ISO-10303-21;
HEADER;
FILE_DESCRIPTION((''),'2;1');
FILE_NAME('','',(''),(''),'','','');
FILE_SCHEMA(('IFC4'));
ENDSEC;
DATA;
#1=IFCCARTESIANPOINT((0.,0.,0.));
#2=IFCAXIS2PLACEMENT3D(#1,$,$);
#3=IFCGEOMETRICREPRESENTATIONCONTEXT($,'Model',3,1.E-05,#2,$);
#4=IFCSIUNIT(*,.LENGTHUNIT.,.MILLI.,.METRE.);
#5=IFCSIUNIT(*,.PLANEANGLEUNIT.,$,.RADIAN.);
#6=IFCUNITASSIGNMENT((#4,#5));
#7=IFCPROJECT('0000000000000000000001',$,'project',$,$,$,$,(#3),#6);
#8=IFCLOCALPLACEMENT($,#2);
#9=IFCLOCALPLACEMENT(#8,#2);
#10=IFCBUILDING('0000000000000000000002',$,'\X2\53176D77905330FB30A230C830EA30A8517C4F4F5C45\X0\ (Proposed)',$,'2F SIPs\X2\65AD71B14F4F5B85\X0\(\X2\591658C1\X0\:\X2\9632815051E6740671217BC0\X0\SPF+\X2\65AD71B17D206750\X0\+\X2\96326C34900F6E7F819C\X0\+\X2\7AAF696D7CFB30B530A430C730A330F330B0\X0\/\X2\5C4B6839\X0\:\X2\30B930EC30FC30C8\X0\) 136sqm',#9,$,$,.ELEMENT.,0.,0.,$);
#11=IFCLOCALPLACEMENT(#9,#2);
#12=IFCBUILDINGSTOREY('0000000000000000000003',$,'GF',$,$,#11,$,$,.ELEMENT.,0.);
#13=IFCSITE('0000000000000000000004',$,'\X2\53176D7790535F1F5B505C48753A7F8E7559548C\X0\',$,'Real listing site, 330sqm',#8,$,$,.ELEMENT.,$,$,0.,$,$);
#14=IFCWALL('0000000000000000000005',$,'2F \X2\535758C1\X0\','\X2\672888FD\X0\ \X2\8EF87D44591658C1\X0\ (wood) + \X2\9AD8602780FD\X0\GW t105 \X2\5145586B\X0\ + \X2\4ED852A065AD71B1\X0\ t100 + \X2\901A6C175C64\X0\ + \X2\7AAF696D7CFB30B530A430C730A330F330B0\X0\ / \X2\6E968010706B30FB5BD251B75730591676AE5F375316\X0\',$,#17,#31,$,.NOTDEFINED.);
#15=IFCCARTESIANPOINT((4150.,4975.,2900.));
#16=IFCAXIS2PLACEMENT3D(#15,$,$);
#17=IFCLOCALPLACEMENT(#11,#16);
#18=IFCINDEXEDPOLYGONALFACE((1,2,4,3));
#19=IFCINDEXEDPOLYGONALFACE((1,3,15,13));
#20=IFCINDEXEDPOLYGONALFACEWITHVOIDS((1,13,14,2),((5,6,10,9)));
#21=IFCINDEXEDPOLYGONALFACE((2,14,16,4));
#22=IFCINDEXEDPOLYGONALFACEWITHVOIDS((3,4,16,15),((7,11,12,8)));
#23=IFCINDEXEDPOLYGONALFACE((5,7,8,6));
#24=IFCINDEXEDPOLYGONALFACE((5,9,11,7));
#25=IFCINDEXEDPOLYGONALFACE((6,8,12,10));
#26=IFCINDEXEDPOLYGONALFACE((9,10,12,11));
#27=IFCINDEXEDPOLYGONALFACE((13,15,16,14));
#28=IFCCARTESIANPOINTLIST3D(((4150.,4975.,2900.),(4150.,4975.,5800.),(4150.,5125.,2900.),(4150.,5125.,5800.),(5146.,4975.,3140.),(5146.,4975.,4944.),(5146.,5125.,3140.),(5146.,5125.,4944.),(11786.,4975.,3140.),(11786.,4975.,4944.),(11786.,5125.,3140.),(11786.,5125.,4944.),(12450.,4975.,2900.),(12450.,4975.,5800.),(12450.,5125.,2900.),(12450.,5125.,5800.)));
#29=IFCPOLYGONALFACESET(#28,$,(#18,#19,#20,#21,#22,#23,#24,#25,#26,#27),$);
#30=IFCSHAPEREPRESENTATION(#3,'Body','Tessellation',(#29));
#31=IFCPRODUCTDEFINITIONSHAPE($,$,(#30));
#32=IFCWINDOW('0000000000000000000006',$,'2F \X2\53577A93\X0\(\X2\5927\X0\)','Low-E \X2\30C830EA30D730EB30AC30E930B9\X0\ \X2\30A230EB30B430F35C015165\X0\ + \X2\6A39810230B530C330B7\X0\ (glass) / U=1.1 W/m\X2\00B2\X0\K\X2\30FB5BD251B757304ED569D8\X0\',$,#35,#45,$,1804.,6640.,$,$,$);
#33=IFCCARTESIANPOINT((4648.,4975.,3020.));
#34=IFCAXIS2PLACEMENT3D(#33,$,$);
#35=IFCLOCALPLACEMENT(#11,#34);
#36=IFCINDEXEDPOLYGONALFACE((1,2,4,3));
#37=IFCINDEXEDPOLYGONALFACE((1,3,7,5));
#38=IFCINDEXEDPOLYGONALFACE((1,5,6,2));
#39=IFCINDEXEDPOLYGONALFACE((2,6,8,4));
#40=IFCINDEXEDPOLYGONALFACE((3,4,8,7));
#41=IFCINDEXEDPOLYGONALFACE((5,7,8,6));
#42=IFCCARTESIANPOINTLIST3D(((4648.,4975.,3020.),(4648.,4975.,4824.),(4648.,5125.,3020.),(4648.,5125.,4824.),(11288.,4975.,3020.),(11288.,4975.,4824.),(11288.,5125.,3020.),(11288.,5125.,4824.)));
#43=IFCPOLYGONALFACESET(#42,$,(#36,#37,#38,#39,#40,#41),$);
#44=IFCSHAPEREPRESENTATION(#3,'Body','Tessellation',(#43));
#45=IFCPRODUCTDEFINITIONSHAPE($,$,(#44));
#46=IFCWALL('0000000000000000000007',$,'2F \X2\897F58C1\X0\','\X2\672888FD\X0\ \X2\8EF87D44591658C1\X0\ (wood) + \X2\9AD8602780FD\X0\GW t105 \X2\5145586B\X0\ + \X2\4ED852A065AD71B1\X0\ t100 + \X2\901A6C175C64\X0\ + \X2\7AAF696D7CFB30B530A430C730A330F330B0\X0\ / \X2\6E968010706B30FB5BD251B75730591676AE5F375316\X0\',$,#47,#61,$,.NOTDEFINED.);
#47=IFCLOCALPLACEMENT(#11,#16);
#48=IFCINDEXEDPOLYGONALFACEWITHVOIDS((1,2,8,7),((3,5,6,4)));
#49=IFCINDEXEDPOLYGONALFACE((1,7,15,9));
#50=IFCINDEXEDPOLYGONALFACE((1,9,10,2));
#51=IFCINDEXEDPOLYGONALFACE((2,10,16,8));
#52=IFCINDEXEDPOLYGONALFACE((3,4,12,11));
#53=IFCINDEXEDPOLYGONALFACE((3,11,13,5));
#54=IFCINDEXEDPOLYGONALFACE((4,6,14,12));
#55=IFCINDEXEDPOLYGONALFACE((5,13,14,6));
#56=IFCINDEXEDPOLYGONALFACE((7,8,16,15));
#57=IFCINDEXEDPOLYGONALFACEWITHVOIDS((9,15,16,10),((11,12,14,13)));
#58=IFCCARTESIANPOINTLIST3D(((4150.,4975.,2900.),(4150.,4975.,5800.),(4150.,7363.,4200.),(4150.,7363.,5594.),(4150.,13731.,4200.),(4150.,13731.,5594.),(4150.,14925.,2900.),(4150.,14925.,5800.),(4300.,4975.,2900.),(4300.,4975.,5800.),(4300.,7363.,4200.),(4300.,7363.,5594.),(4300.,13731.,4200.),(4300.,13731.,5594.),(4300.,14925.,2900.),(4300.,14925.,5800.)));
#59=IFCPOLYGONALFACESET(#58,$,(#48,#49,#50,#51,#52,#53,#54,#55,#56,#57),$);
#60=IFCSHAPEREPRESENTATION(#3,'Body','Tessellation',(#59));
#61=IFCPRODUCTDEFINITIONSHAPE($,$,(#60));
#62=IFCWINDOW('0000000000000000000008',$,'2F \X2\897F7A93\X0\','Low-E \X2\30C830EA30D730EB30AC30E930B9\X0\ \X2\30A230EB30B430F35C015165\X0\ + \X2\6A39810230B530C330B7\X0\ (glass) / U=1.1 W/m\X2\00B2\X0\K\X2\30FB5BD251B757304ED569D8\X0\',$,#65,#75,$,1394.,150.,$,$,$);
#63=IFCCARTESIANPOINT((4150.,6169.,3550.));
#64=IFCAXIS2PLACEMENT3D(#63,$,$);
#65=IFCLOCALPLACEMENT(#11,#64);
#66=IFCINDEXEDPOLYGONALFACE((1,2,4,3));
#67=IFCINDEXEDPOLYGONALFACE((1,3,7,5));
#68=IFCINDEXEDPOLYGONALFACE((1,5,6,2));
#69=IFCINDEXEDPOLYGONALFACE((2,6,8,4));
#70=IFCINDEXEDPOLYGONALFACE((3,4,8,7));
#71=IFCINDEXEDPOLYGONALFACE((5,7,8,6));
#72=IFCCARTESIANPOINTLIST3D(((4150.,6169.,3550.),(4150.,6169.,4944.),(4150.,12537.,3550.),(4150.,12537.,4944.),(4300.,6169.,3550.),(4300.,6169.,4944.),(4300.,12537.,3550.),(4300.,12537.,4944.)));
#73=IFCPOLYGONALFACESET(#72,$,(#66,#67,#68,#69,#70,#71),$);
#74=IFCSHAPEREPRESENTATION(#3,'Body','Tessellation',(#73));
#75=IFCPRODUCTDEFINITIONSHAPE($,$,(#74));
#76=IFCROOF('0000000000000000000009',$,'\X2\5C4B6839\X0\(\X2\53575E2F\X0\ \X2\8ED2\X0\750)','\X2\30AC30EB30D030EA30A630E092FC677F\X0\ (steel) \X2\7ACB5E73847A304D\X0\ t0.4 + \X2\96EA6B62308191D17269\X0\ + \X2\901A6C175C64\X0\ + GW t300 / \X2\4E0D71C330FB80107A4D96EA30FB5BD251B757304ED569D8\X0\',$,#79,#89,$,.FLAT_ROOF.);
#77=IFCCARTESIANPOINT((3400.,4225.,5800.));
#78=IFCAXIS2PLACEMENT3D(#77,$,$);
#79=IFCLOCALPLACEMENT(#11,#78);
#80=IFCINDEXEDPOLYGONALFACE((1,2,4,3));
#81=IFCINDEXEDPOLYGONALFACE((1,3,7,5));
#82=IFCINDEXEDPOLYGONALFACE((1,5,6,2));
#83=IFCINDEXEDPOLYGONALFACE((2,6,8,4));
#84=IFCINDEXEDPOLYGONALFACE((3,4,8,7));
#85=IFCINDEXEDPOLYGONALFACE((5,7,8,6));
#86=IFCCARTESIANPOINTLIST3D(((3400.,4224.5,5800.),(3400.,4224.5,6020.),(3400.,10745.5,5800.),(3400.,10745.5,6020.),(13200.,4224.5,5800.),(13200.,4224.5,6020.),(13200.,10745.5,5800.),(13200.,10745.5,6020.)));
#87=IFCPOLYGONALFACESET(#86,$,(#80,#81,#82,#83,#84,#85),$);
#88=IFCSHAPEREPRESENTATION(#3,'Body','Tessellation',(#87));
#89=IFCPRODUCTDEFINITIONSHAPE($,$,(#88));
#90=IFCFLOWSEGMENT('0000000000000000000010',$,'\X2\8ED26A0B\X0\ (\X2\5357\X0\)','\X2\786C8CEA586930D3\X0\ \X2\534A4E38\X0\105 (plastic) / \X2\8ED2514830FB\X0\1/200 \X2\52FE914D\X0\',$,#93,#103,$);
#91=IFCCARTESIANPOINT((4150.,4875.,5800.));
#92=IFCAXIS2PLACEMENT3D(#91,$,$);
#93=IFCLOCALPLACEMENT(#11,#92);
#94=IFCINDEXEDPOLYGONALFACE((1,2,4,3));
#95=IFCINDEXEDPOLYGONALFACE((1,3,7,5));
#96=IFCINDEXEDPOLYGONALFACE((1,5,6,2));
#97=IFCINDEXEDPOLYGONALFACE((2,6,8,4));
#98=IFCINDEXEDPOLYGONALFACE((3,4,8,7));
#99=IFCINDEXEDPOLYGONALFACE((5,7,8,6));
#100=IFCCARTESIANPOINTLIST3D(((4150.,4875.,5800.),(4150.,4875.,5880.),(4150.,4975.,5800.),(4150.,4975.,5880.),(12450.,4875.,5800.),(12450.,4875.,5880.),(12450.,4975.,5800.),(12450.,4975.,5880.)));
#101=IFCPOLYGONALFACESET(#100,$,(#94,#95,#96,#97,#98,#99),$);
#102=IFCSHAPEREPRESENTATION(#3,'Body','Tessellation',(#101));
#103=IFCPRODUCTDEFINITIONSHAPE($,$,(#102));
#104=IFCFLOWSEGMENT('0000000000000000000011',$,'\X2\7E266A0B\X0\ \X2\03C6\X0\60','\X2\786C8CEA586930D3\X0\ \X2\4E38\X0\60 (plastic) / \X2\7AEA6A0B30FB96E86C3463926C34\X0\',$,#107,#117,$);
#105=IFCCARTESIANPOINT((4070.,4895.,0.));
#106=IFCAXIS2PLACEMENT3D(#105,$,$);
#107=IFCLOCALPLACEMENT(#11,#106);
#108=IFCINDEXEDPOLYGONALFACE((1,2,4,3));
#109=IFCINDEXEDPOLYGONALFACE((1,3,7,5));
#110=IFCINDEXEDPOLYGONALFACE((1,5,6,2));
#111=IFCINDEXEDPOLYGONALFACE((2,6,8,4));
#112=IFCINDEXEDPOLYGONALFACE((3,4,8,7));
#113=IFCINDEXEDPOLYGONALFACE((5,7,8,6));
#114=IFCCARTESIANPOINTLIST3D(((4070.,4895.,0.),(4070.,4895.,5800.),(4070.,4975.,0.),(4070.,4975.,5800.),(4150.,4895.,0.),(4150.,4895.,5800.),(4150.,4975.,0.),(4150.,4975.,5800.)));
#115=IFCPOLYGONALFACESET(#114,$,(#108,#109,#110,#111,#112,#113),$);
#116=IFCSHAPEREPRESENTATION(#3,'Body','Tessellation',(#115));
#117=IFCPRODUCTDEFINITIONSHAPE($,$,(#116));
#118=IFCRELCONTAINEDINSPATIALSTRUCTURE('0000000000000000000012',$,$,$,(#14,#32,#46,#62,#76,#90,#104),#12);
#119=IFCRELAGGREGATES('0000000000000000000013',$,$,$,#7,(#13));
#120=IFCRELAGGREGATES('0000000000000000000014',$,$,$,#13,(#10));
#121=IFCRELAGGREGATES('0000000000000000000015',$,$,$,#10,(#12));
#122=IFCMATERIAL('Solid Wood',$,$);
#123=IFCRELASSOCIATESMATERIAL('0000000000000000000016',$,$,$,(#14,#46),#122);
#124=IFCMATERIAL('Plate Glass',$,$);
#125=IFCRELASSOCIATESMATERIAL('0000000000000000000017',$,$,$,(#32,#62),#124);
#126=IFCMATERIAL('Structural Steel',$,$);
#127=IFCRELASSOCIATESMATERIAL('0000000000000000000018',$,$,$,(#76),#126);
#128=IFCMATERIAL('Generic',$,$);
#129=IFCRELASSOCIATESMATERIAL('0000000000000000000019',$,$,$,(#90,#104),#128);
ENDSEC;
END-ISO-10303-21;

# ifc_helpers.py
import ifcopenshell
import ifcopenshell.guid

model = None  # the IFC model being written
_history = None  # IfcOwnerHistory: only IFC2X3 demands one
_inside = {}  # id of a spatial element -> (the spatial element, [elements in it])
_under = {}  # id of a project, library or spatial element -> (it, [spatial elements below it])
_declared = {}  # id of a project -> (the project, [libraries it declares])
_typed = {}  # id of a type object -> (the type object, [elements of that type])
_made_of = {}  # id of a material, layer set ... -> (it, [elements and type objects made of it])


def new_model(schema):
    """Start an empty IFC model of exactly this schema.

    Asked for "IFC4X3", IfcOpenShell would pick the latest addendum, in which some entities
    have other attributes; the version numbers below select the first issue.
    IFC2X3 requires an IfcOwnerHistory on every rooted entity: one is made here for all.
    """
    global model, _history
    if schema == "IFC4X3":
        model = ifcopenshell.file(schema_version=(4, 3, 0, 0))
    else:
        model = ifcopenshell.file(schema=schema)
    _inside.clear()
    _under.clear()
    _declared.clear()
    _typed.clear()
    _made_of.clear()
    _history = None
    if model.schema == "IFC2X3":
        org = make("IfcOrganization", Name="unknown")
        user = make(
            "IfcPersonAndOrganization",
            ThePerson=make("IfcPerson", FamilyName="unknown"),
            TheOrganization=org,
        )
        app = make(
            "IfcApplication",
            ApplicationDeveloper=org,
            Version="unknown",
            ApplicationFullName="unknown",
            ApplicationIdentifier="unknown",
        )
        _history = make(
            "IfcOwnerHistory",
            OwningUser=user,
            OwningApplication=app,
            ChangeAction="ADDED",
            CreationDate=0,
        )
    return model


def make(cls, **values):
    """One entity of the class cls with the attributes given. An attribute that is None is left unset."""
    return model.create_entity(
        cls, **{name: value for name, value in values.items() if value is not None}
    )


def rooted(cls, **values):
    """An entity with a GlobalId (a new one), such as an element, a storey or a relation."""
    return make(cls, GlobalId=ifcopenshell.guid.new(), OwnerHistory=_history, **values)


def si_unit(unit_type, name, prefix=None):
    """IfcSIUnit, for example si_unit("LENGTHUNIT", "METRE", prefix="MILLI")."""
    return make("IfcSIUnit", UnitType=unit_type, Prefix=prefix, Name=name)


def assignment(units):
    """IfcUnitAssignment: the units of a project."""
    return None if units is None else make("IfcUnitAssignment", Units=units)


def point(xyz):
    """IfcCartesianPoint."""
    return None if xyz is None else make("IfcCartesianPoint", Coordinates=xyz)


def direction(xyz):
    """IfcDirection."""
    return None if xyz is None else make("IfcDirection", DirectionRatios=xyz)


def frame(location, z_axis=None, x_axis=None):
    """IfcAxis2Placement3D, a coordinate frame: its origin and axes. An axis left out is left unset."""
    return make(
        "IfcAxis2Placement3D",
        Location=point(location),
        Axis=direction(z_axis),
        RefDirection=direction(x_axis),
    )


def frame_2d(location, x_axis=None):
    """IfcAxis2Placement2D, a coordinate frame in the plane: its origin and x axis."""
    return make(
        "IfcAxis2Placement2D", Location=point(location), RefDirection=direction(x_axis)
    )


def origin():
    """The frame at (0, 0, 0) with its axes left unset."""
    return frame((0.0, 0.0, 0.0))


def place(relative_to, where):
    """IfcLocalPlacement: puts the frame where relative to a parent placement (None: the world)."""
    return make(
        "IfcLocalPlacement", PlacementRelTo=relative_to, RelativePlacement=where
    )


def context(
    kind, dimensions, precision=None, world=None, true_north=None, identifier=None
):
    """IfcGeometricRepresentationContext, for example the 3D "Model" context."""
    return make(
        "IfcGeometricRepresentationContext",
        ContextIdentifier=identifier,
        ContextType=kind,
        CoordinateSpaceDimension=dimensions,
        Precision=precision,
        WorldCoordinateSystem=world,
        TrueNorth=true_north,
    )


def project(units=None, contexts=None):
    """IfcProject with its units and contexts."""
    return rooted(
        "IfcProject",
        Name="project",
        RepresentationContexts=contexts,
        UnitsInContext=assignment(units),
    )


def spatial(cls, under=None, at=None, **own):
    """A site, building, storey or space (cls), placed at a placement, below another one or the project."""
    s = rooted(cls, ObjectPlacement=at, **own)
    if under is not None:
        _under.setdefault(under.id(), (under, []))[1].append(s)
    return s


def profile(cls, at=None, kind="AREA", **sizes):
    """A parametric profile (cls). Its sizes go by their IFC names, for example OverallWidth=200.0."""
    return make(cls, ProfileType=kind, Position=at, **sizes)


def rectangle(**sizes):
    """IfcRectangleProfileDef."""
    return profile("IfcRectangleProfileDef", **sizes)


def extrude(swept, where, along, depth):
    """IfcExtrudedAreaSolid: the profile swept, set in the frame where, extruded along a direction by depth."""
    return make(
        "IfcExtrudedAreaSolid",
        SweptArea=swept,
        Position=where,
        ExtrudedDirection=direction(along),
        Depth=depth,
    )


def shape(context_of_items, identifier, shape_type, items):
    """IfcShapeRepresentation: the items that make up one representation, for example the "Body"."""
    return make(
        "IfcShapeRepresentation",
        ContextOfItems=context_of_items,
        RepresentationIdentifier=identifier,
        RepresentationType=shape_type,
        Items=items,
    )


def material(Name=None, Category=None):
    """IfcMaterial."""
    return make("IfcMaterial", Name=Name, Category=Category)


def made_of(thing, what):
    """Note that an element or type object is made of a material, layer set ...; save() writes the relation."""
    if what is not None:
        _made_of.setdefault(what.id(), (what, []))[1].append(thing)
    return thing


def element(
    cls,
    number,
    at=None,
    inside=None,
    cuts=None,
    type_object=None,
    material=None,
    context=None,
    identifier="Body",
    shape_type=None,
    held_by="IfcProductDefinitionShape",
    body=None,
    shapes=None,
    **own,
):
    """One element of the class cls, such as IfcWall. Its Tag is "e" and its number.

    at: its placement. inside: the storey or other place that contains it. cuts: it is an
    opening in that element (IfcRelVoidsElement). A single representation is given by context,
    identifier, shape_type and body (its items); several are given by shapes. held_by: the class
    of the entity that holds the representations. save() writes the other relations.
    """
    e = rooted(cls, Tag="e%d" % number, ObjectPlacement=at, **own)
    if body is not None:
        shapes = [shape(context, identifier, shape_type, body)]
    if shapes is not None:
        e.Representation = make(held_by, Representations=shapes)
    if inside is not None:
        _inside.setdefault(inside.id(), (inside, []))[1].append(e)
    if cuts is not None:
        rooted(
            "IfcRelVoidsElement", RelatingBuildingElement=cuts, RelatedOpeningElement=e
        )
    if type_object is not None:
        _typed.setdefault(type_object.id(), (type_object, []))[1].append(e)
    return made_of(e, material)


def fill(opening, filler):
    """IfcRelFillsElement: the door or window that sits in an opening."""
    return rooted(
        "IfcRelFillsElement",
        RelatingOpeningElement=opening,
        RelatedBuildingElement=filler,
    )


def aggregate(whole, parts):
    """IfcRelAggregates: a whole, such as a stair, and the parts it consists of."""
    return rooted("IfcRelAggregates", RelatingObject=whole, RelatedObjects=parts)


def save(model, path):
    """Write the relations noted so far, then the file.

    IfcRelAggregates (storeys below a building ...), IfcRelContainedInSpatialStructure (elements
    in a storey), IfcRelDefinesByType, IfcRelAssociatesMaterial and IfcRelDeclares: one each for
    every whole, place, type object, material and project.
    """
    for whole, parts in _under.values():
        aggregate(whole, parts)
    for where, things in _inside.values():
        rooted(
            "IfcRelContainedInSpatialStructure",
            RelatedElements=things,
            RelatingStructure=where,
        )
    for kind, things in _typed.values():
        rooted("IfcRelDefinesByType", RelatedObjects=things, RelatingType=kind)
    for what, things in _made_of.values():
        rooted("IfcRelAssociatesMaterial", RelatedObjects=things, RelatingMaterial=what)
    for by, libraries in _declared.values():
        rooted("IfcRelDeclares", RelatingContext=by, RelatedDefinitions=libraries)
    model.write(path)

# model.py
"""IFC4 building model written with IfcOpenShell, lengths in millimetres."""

from ifc_helpers import new_model, si_unit, frame, frame_2d, origin, place, context, project, spatial, rectangle, extrude, material, element, fill, save


model = new_model("IFC4")

# Units and contexts
model_context = context("Model", 3, precision=1e-05, world=origin())
ifc_project = project(units=[si_unit("LENGTHUNIT", "METRE", prefix="MILLI"), si_unit("PLANEANGLEUNIT", "RADIAN")], contexts=[model_context])

# Site, building, storey
site_placement = place(None, origin())
site = spatial("IfcSite", under=ifc_project, at=site_placement, Name="北海道弟子屈町美留和", ObjectType="Real listing site, 330sqm", CompositionType="ELEMENT", RefElevation=0.0)
building_placement = place(site_placement, origin())
building = spatial("IfcBuilding", under=site, at=building_placement, Name="北海道・アトリエ兼住居 (Proposed)", ObjectType="2F SIPs断熱住宅(外壁:防腐処理無節SPF+断熱素材+防水透湿膜+窯業系サイディング/屋根:スレート) 136sqm", CompositionType="ELEMENT", ElevationOfRefHeight=0.0, ElevationOfTerrain=0.0)
storey_placement = place(building_placement, origin())
storey = spatial("IfcBuildingStorey", under=building, at=storey_placement, Name="GF", CompositionType="ELEMENT", Elevation=0.0)

# Shared definitions
ifc_material_1 = material(Name="Solid Wood")

# Shared definitions
ifc_material_2 = material(Name="Plate Glass")

# Walls, openings, windows
wall_1_placement = place(storey_placement, frame((4150.0, 4975.0, 2900.0)))
wall_1 = element("IfcWall", 1, at=wall_1_placement, inside=storey, material=ifc_material_1, Name="2F 南壁", Description="木製 軸組外壁 (wood) + 高性能GW t105 充填 + 付加断熱 t100 + 通気層 + 窯業系サイディング / 準耐火・寒冷地外皮強化", PredefinedType="NOTDEFINED", context=model_context, shape_type="SweptSolid", body=[
    extrude(rectangle(XDim=8300.0, YDim=150.0, at=frame_2d((4150.0, 75.0))), frame((4150.0, 4975.0, 2900.0)), (0.0, 0.0, 1.0), 2900.0),
])
opening_1_placement = place(storey_placement, frame((4648.0, 4975.0, 3020.0)))
opening_1 = element("IfcOpeningElement", 2, at=opening_1_placement, cuts=wall_1, PredefinedType="NOTDEFINED", context=model_context, shape_type="SweptSolid", body=[
    extrude(rectangle(XDim=6640.0, YDim=150.0, at=frame_2d((3320.0, 75.0))), frame((4648.0, 4975.0, 3020.0)), (0.0, 0.0, 1.0), 1804.0),
])
window_1_placement = place(storey_placement, frame((4648.0, 4975.0, 3020.0)))
window_1 = element("IfcWindow", 3, at=window_1_placement, inside=storey, material=ifc_material_2, Name="2F 南窓(大)", Description="Low-E トリプルガラス アルゴン封入 + 樹脂サッシ (glass) / U=1.1 W/m²K・寒冷地仕様", OverallHeight=1804.0, OverallWidth=6640.0, context=model_context, shape_type="SweptSolid", body=[
    extrude(rectangle(XDim=6640.0, YDim=150.0, at=frame_2d((3320.0, 75.0))), frame((4648.0, 4975.0, 3020.0)), (0.0, 0.0, 1.0), 1804.0),
])
fill(opening_1, window_1)
wall_2_placement = place(storey_placement, frame((4150.0, 4975.0, 2900.0)))
wall_2 = element("IfcWall", 4, at=wall_2_placement, inside=storey, material=ifc_material_1, Name="2F 西壁", Description="木製 軸組外壁 (wood) + 高性能GW t105 充填 + 付加断熱 t100 + 通気層 + 窯業系サイディング / 準耐火・寒冷地外皮強化", PredefinedType="NOTDEFINED", context=model_context, shape_type="SweptSolid", body=[
    extrude(rectangle(XDim=150.0, YDim=9950.0, at=frame_2d((75.0, 4975.0))), frame((4150.0, 4975.0, 2900.0)), (0.0, 0.0, 1.0), 2900.0),
])
opening_2_placement = place(storey_placement, frame((4150.0, 6169.0, 3550.0)))
opening_2 = element("IfcOpeningElement", 5, at=opening_2_placement, cuts=wall_2, PredefinedType="NOTDEFINED", context=model_context, shape_type="SweptSolid", body=[
    extrude(rectangle(XDim=150.0, YDim=6368.0, at=frame_2d((75.0, 3184.0))), frame((4150.0, 6169.0, 3550.0)), (0.0, 0.0, 1.0), 1394.0),
])
window_2_placement = place(storey_placement, frame((4150.0, 6169.0, 3550.0)))
window_2 = element("IfcWindow", 6, at=window_2_placement, inside=storey, material=ifc_material_2, Name="2F 西窓", Description="Low-E トリプルガラス アルゴン封入 + 樹脂サッシ (glass) / U=1.1 W/m²K・寒冷地仕様", OverallHeight=1394.0, OverallWidth=150.0, context=model_context, shape_type="SweptSolid", body=[
    extrude(rectangle(XDim=150.0, YDim=6368.0, at=frame_2d((75.0, 3184.0))), frame((4150.0, 6169.0, 3550.0)), (0.0, 0.0, 1.0), 1394.0),
])
fill(opening_2, window_2)

# Roof
ifc_material_3 = material(Name="Structural Steel")
for number, where, name in (
    (7, (3400.0, 4225.0, 5800.0), "屋根(南帯 軒750)"),
):
    element("IfcRoof", number, at=place(storey_placement, frame(where)), inside=storey, material=ifc_material_3, Name=name, Description="ガルバリウム鋼板 (steel) 立平葺き t0.4 + 雪止め金物 + 通気層 + GW t300 / 不燃・耐積雪・寒冷地仕様", PredefinedType="FLAT_ROOF", context=model_context, shape_type="SweptSolid", body=[
        extrude(rectangle(XDim=9800.0, YDim=6521.0, at=frame_2d((4900.0, 3260.0))), frame((3400.0, 4225.0, 5800.0)), (0.0, 0.0, 1.0), 220.0),
    ])

# Flow segments
ifc_material_4 = material(Name="Generic")
flow_segment_1_placement = place(storey_placement, frame((4150.0, 4875.0, 5800.0)))
element("IfcFlowSegment", 8, at=flow_segment_1_placement, inside=storey, material=ifc_material_4, Name="軒樋 (南)", Description="硬質塩ビ 半丸105 (plastic) / 軒先・1/200 勾配", context=model_context, shape_type="SweptSolid", body=[
    extrude(rectangle(XDim=8300.0, YDim=100.0, at=frame_2d((4150.0, 50.0))), frame((4150.0, 4875.0, 5800.0)), (0.0, 0.0, 1.0), 80.0),
])
flow_segment_2_placement = place(storey_placement, frame((4070.0, 4895.0, 0.0)))
element("IfcFlowSegment", 9, at=flow_segment_2_placement, inside=storey, material=ifc_material_4, Name="縦樋 φ60", Description="硬質塩ビ 丸60 (plastic) / 竪樋・雨水排水", context=model_context, shape_type="SweptSolid", body=[
    extrude(rectangle(XDim=80.0, YDim=80.0, at=frame_2d((40.0, 40.0))), frame((4070.0, 4895.0, 0.0)), (0.0, 0.0, 1.0), 5800.0),
])

save(model, "model.ifc")
